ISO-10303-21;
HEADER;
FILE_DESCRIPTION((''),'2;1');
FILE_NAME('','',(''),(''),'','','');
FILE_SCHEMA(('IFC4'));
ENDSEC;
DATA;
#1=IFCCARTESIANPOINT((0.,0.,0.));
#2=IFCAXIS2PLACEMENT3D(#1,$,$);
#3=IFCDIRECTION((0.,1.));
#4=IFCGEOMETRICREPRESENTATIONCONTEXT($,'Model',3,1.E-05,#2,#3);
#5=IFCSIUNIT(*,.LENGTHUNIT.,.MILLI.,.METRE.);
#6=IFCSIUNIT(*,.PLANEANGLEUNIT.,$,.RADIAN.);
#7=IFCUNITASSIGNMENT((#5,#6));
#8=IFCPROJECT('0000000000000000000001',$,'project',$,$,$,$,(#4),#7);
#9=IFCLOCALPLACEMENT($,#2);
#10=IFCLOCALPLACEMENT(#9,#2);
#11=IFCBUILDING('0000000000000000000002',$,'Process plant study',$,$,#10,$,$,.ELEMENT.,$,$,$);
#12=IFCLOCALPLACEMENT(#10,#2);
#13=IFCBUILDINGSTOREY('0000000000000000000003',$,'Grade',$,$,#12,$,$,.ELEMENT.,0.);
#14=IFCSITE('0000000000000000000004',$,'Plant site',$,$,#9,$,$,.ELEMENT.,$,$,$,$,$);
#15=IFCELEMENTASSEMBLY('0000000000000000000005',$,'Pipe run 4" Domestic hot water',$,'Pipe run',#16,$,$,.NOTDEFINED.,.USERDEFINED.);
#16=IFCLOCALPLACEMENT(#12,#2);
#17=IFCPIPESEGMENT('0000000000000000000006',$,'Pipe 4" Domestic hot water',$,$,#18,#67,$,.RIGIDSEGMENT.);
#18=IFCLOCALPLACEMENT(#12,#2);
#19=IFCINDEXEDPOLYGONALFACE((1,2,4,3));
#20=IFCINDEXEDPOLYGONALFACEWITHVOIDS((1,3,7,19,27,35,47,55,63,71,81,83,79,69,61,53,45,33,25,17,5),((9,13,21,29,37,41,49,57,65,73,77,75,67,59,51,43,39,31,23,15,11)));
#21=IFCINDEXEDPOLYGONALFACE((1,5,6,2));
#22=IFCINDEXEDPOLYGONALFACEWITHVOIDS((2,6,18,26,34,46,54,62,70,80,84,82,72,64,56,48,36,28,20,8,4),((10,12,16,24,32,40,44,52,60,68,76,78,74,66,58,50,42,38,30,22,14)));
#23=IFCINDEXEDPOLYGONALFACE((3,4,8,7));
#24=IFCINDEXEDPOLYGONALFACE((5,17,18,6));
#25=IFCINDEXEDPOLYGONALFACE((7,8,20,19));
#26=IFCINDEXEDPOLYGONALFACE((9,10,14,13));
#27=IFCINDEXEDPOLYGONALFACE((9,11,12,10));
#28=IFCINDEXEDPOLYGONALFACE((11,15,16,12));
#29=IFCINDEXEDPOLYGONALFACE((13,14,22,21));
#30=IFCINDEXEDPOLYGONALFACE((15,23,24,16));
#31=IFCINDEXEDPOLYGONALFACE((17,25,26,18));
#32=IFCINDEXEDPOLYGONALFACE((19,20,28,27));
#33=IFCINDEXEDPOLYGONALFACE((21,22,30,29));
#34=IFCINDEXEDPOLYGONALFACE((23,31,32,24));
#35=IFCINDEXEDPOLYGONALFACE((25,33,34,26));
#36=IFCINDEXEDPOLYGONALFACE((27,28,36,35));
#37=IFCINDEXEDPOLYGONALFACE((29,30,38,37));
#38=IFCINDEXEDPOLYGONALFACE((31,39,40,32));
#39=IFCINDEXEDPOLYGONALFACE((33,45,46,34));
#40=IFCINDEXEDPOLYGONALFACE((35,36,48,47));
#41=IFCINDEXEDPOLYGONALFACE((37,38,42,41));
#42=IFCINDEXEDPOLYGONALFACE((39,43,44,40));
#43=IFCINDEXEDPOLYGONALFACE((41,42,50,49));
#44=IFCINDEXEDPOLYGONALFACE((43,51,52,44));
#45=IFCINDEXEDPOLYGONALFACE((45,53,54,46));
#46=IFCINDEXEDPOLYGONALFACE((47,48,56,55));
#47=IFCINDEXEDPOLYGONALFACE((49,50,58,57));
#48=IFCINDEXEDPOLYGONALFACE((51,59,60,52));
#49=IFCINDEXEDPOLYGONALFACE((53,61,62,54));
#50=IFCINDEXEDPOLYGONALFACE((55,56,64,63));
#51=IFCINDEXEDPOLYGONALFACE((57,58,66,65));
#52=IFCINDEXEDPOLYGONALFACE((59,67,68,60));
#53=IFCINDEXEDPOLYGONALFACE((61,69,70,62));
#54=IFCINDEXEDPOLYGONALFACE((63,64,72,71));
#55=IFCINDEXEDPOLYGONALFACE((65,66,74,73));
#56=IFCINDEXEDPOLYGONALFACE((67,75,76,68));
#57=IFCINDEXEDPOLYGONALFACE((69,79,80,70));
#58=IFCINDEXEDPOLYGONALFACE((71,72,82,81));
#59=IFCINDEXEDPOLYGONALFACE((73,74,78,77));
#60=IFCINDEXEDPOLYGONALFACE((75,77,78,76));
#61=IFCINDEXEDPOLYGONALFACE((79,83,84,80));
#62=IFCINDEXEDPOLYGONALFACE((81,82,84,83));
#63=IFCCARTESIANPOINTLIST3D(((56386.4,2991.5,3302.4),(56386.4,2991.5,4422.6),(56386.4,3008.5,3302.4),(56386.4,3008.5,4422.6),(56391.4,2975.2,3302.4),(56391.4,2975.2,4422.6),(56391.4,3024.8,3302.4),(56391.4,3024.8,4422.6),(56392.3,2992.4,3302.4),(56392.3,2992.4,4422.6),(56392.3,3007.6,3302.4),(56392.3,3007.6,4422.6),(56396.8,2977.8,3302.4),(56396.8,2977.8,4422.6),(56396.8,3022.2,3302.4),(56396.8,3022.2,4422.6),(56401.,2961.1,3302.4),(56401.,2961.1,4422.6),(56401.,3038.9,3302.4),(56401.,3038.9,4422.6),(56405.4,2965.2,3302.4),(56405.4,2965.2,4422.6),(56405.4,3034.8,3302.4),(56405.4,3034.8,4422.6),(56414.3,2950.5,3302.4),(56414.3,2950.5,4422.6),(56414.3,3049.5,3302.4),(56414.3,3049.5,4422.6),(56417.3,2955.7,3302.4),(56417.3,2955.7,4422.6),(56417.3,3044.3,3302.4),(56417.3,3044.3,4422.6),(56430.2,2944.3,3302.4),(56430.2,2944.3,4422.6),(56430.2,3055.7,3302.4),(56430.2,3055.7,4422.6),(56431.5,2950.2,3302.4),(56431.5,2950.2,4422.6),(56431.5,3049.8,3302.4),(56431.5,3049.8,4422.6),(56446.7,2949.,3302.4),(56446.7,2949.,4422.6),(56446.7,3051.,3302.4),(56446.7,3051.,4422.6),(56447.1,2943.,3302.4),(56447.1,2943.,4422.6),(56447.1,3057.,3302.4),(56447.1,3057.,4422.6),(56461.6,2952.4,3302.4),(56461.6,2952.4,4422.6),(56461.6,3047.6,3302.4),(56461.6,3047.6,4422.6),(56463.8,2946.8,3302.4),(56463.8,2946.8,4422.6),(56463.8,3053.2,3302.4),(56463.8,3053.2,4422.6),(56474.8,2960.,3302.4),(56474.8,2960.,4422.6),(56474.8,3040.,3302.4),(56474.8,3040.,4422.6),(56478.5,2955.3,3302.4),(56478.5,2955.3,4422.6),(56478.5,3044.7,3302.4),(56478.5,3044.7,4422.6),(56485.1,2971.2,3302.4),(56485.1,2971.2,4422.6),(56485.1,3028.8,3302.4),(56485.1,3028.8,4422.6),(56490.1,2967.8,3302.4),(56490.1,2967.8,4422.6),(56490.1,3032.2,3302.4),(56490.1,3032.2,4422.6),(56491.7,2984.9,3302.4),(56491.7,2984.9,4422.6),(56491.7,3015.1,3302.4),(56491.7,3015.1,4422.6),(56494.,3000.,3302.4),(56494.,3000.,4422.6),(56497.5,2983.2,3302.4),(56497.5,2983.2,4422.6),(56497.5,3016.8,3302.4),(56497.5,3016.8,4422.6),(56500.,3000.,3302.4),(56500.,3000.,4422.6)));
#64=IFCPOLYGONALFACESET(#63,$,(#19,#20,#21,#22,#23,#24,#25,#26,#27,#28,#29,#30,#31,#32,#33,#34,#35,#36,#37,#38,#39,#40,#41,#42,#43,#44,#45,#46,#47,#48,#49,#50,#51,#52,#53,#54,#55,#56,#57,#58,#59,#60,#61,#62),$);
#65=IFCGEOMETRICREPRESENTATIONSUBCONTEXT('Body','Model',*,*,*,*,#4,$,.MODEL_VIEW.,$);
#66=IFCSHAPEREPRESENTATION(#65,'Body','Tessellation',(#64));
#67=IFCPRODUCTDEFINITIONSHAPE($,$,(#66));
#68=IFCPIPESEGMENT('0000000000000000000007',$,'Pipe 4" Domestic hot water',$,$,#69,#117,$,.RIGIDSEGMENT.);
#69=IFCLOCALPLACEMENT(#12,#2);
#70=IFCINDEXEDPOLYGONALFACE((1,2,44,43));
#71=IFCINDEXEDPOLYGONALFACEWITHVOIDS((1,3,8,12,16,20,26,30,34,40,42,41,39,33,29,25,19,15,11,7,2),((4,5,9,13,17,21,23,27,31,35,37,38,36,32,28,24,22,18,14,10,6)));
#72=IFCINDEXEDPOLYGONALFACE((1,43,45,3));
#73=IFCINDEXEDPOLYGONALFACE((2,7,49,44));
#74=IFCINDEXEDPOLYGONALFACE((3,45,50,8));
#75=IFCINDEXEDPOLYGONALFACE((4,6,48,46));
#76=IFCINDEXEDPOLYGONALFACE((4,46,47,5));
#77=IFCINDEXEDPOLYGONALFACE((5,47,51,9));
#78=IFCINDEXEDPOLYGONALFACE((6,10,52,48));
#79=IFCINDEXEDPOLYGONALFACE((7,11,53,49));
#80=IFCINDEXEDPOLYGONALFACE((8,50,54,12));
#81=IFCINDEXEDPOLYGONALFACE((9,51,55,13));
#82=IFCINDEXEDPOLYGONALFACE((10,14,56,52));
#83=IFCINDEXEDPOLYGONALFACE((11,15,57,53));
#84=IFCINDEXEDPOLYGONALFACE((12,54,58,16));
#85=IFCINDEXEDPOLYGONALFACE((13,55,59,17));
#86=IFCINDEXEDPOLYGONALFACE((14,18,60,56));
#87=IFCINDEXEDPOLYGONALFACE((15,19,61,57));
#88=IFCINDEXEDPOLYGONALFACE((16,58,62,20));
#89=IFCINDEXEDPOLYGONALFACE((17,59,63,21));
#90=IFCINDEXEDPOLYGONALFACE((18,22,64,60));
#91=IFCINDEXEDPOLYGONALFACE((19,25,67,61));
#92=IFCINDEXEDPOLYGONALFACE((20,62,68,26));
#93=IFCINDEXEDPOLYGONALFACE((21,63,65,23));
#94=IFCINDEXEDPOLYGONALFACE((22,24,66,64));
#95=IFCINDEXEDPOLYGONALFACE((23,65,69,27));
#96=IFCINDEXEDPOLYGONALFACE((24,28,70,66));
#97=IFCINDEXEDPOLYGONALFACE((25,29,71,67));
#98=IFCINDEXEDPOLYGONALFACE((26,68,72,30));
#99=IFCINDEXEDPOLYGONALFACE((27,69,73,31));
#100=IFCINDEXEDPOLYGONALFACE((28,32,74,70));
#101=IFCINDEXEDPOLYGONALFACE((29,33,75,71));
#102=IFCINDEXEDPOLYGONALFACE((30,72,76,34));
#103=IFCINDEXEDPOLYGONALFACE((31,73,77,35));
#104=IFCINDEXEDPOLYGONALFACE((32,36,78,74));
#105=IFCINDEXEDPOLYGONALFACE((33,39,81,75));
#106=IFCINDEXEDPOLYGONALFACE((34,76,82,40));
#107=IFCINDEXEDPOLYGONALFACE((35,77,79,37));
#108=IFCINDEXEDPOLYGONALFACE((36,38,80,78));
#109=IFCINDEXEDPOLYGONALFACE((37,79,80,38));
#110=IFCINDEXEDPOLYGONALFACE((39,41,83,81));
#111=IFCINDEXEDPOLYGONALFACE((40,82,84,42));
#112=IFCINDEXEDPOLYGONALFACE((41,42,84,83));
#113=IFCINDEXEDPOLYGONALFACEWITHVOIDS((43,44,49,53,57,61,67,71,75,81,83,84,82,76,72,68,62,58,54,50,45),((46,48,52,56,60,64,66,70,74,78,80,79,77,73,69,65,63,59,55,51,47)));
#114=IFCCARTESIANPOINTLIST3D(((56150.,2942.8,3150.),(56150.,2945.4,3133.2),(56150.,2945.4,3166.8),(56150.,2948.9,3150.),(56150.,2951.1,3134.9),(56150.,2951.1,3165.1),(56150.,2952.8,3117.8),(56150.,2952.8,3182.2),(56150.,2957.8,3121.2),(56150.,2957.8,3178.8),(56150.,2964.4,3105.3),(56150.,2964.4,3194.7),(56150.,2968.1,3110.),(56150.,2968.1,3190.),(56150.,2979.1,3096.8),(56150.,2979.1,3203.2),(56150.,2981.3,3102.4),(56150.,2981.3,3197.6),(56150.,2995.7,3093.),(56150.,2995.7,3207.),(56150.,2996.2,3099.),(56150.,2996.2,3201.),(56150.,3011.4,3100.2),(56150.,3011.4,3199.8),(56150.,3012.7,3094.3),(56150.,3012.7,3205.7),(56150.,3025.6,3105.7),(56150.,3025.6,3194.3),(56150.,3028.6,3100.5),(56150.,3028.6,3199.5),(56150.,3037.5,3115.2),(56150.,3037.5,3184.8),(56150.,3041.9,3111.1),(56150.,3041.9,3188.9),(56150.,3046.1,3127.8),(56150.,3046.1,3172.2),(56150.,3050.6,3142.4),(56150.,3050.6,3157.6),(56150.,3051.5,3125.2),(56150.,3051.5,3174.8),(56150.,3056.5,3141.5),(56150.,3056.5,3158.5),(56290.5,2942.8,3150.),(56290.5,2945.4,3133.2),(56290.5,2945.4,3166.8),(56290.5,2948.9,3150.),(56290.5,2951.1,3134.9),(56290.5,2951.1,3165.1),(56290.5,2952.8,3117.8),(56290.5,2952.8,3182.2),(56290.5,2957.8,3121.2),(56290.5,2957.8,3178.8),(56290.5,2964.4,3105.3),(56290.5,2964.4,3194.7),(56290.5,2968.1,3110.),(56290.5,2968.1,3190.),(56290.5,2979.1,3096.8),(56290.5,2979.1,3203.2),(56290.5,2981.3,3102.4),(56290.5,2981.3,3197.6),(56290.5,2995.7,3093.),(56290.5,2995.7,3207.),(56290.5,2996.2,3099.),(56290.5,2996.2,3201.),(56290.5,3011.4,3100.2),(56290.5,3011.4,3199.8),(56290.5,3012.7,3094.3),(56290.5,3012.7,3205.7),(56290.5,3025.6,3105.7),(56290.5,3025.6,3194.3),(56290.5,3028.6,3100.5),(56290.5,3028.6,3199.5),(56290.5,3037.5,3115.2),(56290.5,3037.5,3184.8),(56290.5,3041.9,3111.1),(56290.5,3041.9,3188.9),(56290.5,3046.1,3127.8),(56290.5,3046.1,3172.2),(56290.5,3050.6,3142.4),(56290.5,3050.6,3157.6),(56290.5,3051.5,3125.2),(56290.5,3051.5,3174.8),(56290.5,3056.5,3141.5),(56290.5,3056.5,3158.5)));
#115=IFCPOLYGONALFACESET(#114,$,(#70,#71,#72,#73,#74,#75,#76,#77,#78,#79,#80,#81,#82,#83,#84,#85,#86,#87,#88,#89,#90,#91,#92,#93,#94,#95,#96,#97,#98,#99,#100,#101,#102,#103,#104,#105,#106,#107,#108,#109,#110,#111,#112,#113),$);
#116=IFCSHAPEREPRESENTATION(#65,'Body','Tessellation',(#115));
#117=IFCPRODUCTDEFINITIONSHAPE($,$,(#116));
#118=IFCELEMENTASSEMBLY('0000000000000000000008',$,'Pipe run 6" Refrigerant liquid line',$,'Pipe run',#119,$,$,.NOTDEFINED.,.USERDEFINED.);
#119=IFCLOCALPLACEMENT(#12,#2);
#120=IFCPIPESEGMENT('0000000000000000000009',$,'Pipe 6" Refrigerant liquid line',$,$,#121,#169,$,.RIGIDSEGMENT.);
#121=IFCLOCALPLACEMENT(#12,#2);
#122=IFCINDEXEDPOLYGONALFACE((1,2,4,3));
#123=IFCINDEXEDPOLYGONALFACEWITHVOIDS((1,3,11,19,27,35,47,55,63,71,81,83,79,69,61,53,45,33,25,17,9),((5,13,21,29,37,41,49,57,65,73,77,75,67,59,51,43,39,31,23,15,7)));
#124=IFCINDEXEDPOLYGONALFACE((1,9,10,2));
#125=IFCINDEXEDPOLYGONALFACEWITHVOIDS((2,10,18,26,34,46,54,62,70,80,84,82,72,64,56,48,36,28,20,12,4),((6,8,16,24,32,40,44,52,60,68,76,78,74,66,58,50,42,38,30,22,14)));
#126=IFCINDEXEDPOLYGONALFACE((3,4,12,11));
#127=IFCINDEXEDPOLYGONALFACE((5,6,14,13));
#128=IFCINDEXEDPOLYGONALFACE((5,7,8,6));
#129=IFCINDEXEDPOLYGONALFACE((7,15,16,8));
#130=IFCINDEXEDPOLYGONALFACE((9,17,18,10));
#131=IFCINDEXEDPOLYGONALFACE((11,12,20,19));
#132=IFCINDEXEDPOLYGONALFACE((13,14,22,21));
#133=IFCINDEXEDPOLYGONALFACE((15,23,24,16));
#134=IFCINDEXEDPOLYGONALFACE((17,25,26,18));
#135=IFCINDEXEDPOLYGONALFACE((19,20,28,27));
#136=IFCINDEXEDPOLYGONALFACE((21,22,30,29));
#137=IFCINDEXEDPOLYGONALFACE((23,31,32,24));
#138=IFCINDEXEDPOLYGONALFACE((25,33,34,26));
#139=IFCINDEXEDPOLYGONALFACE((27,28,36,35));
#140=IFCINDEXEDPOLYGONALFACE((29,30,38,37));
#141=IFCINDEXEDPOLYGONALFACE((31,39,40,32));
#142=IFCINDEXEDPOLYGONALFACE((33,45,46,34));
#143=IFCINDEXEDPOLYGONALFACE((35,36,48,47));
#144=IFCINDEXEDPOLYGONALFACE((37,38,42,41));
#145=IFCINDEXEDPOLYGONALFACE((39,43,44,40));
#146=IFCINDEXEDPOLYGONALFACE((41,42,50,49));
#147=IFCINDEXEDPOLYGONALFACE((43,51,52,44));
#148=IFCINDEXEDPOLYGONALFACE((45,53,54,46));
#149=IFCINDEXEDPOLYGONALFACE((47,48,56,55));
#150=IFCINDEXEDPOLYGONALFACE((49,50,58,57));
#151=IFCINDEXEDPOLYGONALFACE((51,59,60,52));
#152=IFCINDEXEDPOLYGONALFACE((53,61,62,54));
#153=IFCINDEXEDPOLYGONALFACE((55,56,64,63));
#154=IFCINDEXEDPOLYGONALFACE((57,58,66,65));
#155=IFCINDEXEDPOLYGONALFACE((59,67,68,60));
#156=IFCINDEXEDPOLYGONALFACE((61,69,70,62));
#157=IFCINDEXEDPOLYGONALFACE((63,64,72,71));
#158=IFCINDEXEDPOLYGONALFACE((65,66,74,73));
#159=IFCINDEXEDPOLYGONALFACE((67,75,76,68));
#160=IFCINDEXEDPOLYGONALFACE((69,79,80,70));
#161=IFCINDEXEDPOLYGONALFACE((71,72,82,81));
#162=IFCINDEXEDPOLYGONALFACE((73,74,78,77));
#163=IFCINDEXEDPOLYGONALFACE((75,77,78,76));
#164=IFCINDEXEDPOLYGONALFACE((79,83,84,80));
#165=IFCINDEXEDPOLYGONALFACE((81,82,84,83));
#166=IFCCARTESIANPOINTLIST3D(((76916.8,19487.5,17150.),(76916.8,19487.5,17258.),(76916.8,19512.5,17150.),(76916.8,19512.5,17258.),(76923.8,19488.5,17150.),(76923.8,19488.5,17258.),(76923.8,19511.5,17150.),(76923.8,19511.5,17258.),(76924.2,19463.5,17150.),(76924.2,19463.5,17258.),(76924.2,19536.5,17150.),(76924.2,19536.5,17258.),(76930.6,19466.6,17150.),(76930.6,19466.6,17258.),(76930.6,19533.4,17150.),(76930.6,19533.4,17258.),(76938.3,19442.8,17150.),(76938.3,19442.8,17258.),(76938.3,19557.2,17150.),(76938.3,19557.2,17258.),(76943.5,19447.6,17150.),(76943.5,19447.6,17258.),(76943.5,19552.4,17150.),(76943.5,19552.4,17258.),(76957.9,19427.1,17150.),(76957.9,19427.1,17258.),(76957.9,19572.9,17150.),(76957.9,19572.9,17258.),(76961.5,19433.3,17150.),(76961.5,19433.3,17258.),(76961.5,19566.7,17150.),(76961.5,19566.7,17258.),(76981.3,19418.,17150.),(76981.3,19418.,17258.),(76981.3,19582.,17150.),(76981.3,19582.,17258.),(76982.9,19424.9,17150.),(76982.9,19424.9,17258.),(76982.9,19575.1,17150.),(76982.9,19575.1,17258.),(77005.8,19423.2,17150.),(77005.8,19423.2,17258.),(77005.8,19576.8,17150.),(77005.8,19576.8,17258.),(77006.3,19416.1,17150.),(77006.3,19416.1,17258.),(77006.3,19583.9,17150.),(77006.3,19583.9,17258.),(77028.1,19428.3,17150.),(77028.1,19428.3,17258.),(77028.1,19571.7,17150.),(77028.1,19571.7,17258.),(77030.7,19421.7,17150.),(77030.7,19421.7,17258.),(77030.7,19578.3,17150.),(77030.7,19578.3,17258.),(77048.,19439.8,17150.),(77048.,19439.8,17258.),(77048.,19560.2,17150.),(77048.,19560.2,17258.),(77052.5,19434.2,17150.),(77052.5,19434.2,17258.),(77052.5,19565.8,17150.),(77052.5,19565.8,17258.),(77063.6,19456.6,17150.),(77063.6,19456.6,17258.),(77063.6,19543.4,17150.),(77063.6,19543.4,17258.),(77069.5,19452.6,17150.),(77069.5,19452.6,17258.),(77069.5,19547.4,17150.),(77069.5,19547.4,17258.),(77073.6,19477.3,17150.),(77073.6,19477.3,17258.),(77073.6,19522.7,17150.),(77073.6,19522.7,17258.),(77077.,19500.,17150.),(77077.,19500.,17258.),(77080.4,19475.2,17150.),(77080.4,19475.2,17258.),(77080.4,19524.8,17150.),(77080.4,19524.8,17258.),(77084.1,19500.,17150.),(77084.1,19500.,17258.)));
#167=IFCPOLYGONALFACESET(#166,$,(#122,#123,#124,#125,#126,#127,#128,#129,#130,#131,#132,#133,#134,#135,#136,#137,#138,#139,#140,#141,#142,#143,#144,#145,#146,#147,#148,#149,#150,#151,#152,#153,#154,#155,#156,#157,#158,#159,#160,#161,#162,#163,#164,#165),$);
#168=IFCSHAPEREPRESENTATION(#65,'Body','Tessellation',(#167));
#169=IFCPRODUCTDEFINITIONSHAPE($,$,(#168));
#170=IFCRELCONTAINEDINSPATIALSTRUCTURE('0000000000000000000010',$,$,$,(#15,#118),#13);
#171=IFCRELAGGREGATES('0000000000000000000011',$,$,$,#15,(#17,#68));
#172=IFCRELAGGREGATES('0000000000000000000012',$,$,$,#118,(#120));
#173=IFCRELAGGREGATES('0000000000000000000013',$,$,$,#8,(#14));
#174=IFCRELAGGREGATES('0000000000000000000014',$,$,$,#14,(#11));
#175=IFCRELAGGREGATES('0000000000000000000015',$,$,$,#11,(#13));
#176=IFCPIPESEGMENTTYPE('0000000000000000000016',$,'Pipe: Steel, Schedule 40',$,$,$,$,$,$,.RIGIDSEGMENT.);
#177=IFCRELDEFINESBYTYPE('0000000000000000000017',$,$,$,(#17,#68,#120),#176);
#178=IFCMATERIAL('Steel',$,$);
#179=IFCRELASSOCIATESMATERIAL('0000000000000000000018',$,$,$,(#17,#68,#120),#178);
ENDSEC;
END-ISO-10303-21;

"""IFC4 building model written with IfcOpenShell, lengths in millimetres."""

from ifc_helpers import new_model, si_unit, direction, frame, origin, origin_with_axes, origin_2d, place, context, subcontext, project, spatial, hollow_circle, extrude, material, type_object, element, aggregate, save


model = new_model("IFC4")

# Units and contexts
model_context = context("Model", 3, precision=1e-05, world=origin(), true_north=direction((0.0, 1.0)))
body_context = subcontext(model_context, "Body", "Model", "MODEL_VIEW")
ifc_project = project(units=[si_unit("LENGTHUNIT", "METRE", prefix="MILLI"), si_unit("PLANEANGLEUNIT", "RADIAN")], contexts=[model_context])

# Site, building, storey
site_placement = place(None, origin())
site = spatial("IfcSite", under=ifc_project, at=site_placement, Name="Plant site", CompositionType="ELEMENT")
building_placement = place(site_placement, origin())
building = spatial("IfcBuilding", under=site, at=building_placement, Name="Process plant study", CompositionType="ELEMENT")
storey_placement = place(building_placement, origin())
storey = spatial("IfcBuildingStorey", under=building, at=storey_placement, Name="Grade", CompositionType="ELEMENT", Elevation=0.0)

# Element assemblies, pipe segments
assembly_1_placement = place(storey_placement, origin_with_axes())
assembly_1 = element("IfcElementAssembly", 1, at=assembly_1_placement, inside=storey, Name="Pipe run 4\" Domestic hot water", ObjectType="Pipe run", AssemblyPlace="NOTDEFINED", PredefinedType="USERDEFINED")
ifc_material = material(Name="Steel")
pipe_segment_type = type_object("IfcPipeSegmentType", Name="Pipe: Steel, Schedule 40", PredefinedType="RIGIDSEGMENT")
pipe_segment_1_placement = place(storey_placement, origin_with_axes())
pipe_segment_1 = element("IfcPipeSegment", 2, at=pipe_segment_1_placement, type_object=pipe_segment_type, material=ifc_material, Name="Pipe 4\" Domestic hot water", PredefinedType="RIGIDSEGMENT", context=body_context, shape_type="SweptSolid", body=[
    extrude(hollow_circle(Radius=57.1, WallThickness=6.0, at=origin_2d()), frame((56442.9, 3000.0, 4422.6), z_axis=(0.0, 0.0, -1.0), x_axis=(1.0, 0.0, 0.0)), (0.0, 0.0, 1.0), 1120.2),
])
pipe_segment_2_placement = place(storey_placement, origin_with_axes())
pipe_segment_2 = element("IfcPipeSegment", 3, at=pipe_segment_2_placement, type_object=pipe_segment_type, material=ifc_material, Name="Pipe 4\" Domestic hot water", PredefinedType="RIGIDSEGMENT", context=body_context, shape_type="SweptSolid", body=[
    extrude(hollow_circle(Radius=57.1, WallThickness=6.0, at=origin_2d()), frame((56290.5, 3000.0, 3150.0), z_axis=(-1.0, 0.0, 0.0), x_axis=(0.0, -1.0, 0.0)), (0.0, 0.0, 1.0), 140.5),
])
assembly_2_placement = place(storey_placement, origin_with_axes())
assembly_2 = element("IfcElementAssembly", 4, at=assembly_2_placement, inside=storey, Name="Pipe run 6\" Refrigerant liquid line", ObjectType="Pipe run", AssemblyPlace="NOTDEFINED", PredefinedType="USERDEFINED")
pipe_segment_3_placement = place(storey_placement, origin_with_axes())
pipe_segment_3 = element("IfcPipeSegment", 5, at=pipe_segment_3_placement, type_object=pipe_segment_type, material=ifc_material, Name="Pipe 6\" Refrigerant liquid line", PredefinedType="RIGIDSEGMENT", context=body_context, shape_type="SweptSolid", body=[
    extrude(hollow_circle(Radius=84.1, WallThickness=7.1, at=origin_2d()), frame((77000.0, 19500.0, 17150.0), z_axis=(0.0, 0.0, 1.0), x_axis=(1.0, 0.0, 0.0)), (0.0, 0.0, 1.0), 108.0),
])

aggregate(assembly_1, [pipe_segment_1, pipe_segment_2])
aggregate(assembly_2, [pipe_segment_3])

save(model, "model.ifc")
